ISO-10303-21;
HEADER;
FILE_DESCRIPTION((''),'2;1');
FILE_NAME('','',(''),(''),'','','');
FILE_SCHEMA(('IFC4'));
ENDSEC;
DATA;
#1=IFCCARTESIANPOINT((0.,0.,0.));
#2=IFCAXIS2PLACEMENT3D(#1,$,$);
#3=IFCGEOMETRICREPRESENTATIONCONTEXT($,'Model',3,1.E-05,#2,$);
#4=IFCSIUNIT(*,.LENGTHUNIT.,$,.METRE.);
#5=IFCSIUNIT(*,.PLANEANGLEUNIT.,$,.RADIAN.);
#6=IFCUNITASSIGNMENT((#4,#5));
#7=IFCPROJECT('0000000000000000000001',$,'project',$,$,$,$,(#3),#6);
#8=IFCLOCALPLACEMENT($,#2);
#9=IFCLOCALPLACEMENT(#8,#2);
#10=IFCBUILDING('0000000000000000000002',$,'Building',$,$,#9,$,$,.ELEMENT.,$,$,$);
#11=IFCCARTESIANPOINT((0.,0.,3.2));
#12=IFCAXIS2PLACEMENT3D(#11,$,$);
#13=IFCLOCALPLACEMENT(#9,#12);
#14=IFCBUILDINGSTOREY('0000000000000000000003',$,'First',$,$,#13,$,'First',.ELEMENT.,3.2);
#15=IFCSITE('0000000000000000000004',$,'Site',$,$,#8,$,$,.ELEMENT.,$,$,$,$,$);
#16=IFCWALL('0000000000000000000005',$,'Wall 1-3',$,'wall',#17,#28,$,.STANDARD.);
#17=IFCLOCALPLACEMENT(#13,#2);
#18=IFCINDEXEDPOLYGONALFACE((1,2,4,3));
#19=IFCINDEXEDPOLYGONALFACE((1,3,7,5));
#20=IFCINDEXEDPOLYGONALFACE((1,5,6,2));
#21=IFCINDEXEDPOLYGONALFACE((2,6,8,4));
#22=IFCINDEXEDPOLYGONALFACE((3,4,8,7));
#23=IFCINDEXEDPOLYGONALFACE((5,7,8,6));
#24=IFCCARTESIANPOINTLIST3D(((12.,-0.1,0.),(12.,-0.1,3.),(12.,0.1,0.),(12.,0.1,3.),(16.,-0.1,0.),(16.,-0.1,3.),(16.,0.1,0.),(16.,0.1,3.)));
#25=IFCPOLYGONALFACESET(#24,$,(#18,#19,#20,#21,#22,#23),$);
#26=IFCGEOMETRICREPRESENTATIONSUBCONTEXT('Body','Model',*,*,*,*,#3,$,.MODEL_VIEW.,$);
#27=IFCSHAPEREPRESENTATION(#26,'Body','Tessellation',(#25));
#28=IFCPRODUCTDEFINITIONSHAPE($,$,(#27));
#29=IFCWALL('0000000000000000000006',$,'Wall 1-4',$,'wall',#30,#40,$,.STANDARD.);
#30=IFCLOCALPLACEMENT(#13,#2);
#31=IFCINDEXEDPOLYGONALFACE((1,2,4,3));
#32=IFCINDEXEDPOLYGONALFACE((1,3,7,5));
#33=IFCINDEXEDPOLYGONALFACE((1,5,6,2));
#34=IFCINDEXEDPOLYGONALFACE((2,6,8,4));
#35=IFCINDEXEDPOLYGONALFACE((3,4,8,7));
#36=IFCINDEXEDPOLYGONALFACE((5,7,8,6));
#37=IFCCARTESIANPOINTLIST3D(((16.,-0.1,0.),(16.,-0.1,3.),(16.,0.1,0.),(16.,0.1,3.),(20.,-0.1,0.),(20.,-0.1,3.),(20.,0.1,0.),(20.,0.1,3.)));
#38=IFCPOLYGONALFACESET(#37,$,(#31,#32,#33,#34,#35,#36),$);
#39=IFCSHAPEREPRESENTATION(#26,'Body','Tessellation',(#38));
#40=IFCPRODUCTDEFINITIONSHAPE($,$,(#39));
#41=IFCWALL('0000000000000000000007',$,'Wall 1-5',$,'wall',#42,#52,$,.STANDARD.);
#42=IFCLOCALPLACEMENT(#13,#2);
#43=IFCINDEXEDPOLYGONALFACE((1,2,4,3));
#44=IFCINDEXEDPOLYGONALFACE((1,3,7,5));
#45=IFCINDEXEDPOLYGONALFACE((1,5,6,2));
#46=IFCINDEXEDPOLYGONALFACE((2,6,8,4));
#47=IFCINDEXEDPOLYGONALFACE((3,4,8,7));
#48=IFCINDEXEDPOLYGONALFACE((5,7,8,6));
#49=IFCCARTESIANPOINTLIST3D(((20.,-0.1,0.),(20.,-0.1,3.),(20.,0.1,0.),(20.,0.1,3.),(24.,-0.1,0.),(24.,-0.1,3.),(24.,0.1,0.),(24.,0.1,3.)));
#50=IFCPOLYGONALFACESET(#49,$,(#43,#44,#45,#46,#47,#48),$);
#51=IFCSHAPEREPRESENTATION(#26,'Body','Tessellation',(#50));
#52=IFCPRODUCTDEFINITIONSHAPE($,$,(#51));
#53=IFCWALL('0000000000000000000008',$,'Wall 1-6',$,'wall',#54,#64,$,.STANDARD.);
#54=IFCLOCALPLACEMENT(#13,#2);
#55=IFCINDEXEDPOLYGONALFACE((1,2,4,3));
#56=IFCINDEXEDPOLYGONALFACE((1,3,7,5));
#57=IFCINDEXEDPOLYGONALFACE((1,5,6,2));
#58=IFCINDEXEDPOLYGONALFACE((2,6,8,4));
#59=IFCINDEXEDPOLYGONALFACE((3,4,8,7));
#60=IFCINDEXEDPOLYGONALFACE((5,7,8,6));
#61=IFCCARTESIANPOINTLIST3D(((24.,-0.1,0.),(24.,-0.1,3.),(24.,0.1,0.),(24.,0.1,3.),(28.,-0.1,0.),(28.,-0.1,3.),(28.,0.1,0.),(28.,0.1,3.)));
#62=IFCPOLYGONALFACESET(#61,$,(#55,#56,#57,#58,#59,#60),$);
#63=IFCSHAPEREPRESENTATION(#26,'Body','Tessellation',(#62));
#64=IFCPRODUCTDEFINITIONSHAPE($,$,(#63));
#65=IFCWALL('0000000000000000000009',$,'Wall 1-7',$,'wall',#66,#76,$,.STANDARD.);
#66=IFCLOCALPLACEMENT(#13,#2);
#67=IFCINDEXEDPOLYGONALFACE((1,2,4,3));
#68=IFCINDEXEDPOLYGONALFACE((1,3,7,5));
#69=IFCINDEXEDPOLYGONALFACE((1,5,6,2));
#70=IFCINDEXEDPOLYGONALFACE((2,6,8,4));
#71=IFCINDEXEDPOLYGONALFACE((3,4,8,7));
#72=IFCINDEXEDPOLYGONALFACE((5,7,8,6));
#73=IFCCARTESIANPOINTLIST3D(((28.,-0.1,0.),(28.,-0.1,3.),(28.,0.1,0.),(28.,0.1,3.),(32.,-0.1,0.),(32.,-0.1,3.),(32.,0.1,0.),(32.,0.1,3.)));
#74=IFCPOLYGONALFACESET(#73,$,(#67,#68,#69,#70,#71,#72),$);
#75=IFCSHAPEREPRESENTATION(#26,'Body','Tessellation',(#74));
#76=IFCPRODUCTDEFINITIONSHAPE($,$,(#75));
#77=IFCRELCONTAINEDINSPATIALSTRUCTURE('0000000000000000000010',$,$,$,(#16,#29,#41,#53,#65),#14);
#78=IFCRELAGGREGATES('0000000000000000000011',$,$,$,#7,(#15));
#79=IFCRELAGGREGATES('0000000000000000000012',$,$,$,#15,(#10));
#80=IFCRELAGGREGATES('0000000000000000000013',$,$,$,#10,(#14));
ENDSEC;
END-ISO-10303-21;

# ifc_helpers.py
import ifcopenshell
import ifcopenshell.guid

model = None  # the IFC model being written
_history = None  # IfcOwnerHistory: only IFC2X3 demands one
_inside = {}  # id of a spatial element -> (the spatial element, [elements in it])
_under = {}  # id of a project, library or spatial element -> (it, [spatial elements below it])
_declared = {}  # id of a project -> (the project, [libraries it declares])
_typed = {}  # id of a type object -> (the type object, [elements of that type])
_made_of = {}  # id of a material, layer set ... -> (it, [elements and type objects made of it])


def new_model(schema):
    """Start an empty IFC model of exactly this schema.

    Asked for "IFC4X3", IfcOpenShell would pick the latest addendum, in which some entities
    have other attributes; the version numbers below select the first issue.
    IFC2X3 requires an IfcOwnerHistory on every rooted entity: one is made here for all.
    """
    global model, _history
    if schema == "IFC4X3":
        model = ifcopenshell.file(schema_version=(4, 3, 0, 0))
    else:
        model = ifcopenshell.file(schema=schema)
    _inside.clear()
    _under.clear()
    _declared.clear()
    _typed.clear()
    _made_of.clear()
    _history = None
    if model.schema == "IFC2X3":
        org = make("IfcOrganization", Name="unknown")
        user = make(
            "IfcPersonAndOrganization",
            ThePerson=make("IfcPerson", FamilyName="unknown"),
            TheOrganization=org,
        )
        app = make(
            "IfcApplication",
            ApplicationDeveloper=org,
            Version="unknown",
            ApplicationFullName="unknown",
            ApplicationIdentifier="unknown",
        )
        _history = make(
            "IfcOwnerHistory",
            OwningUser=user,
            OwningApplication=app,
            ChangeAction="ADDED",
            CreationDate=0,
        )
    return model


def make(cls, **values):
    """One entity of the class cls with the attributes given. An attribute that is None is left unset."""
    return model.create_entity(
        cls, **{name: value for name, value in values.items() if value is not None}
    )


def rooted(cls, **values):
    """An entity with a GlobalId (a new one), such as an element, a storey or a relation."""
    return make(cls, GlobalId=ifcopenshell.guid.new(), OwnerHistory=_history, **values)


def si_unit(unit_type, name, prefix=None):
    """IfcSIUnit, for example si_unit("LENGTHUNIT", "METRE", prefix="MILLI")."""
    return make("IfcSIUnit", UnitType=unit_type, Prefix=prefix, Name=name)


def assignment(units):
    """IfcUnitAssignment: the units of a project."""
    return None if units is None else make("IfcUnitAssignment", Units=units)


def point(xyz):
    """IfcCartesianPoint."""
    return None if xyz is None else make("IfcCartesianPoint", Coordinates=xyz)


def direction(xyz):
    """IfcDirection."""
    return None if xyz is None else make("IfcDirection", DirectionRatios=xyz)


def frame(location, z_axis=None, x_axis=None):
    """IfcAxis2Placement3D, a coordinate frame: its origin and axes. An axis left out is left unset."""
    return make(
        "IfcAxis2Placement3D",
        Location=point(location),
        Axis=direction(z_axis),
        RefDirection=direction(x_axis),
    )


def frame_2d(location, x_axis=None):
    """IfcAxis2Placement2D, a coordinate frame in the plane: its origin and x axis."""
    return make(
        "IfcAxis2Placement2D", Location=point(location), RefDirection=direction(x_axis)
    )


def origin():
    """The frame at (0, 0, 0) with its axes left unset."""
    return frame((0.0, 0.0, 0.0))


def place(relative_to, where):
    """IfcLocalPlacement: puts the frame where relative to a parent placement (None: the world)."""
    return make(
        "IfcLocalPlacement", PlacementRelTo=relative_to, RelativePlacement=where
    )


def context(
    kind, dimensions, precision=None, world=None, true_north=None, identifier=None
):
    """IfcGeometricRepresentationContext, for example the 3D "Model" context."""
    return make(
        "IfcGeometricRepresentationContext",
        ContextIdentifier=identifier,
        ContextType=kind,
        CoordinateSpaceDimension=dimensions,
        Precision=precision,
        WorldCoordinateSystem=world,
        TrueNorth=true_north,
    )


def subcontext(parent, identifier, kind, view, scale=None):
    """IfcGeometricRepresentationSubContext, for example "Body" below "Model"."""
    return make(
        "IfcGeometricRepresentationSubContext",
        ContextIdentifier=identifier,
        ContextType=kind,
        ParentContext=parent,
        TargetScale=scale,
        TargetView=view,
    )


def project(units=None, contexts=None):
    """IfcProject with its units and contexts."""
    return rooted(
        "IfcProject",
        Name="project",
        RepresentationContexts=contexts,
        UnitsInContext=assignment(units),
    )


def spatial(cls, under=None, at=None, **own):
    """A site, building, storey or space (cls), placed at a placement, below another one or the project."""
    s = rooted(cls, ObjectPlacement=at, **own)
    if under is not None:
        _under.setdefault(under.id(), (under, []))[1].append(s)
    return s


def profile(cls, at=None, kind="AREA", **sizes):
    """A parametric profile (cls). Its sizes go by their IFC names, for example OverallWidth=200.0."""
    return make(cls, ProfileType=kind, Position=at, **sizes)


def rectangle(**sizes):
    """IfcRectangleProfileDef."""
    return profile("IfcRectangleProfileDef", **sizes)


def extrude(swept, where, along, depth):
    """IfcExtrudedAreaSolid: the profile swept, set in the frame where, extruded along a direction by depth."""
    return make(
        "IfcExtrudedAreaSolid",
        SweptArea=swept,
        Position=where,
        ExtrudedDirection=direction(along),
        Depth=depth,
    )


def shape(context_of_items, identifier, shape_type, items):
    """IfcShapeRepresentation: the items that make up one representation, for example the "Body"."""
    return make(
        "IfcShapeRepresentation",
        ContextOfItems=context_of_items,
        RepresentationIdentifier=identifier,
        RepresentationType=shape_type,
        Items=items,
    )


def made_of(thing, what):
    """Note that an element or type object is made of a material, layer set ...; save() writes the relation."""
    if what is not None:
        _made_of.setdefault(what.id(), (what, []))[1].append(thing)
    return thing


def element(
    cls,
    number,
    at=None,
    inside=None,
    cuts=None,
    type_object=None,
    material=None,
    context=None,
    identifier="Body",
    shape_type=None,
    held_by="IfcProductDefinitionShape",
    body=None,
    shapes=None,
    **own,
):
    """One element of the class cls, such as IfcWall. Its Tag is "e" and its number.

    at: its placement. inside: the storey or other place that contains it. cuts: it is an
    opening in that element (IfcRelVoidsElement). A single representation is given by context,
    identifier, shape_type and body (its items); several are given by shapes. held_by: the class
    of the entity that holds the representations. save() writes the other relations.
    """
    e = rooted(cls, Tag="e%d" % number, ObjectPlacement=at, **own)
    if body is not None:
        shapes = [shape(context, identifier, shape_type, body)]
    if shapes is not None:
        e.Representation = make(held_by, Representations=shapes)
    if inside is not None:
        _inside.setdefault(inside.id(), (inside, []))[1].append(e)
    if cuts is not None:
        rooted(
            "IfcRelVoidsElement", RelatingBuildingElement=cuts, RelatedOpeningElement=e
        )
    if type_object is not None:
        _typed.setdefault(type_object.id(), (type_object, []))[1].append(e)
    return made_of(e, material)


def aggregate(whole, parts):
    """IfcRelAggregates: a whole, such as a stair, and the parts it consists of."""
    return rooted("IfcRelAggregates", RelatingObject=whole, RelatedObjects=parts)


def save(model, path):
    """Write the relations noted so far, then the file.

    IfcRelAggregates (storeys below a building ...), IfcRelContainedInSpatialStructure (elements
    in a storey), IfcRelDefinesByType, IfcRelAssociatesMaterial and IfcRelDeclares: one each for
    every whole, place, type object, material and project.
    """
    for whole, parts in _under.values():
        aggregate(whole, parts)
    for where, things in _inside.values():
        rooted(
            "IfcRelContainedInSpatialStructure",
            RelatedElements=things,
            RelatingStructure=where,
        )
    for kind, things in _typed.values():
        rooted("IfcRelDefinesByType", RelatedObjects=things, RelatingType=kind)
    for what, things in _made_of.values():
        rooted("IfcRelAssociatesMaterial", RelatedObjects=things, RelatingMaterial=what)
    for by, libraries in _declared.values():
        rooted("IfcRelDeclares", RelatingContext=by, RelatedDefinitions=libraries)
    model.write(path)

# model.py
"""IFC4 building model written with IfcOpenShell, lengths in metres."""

from ifc_helpers import new_model, si_unit, frame, frame_2d, origin, place, context, subcontext, project, spatial, rectangle, extrude, element, save


model = new_model("IFC4")

# Units and contexts
model_context = context("Model", 3, precision=1e-05, world=origin())
body_context = subcontext(model_context, "Body", "Model", "MODEL_VIEW")
ifc_project = project(units=[si_unit("LENGTHUNIT", "METRE"), si_unit("PLANEANGLEUNIT", "RADIAN")], contexts=[model_context])

# Site, building, storey
site_placement = place(None, origin())
site = spatial("IfcSite", under=ifc_project, at=site_placement, Name="Site", CompositionType="ELEMENT")
building_placement = place(site_placement, origin())
building = spatial("IfcBuilding", under=site, at=building_placement, Name="Building", CompositionType="ELEMENT")
storey_placement = place(building_placement, frame((0.0, 0.0, 3.2)))
storey = spatial("IfcBuildingStorey", under=building, at=storey_placement, Name="First", LongName="First", CompositionType="ELEMENT", Elevation=3.2)

# Walls
for number, where, z_axis, x_axis, name in (
    (1, (12.0, 0.0, 0.0), (0.0, 0.0, 1.0), (1.0, 0.0, 0.0), "Wall 1-3"),
    (2, (16.0, 0.0, 0.0), (0.0, 0.0, 1.0), (1.0, 0.0, 0.0), "Wall 1-4"),
    (3, (20.0, 0.0, 0.0), (0.0, 0.0, 1.0), (1.0, 0.0, 0.0), "Wall 1-5"),
    (4, (24.0, 0.0, 0.0), (0.0, 0.0, 1.0), (1.0, 0.0, 0.0), "Wall 1-6"),
    (5, (28.0, 0.0, 0.0), (0.0, 0.0, 1.0), (1.0, 0.0, 0.0), "Wall 1-7"),
):
    element("IfcWall", number, at=place(storey_placement, frame(where, z_axis=z_axis, x_axis=x_axis)), inside=storey, Name=name, ObjectType="wall", PredefinedType="STANDARD", context=body_context, shape_type="SweptSolid", body=[
        extrude(rectangle(XDim=4.0, YDim=0.2, at=frame_2d((2.0, 0.0))), origin(), (0.0, 0.0, 1.0), 3.0),
    ])

save(model, "model.ifc")
